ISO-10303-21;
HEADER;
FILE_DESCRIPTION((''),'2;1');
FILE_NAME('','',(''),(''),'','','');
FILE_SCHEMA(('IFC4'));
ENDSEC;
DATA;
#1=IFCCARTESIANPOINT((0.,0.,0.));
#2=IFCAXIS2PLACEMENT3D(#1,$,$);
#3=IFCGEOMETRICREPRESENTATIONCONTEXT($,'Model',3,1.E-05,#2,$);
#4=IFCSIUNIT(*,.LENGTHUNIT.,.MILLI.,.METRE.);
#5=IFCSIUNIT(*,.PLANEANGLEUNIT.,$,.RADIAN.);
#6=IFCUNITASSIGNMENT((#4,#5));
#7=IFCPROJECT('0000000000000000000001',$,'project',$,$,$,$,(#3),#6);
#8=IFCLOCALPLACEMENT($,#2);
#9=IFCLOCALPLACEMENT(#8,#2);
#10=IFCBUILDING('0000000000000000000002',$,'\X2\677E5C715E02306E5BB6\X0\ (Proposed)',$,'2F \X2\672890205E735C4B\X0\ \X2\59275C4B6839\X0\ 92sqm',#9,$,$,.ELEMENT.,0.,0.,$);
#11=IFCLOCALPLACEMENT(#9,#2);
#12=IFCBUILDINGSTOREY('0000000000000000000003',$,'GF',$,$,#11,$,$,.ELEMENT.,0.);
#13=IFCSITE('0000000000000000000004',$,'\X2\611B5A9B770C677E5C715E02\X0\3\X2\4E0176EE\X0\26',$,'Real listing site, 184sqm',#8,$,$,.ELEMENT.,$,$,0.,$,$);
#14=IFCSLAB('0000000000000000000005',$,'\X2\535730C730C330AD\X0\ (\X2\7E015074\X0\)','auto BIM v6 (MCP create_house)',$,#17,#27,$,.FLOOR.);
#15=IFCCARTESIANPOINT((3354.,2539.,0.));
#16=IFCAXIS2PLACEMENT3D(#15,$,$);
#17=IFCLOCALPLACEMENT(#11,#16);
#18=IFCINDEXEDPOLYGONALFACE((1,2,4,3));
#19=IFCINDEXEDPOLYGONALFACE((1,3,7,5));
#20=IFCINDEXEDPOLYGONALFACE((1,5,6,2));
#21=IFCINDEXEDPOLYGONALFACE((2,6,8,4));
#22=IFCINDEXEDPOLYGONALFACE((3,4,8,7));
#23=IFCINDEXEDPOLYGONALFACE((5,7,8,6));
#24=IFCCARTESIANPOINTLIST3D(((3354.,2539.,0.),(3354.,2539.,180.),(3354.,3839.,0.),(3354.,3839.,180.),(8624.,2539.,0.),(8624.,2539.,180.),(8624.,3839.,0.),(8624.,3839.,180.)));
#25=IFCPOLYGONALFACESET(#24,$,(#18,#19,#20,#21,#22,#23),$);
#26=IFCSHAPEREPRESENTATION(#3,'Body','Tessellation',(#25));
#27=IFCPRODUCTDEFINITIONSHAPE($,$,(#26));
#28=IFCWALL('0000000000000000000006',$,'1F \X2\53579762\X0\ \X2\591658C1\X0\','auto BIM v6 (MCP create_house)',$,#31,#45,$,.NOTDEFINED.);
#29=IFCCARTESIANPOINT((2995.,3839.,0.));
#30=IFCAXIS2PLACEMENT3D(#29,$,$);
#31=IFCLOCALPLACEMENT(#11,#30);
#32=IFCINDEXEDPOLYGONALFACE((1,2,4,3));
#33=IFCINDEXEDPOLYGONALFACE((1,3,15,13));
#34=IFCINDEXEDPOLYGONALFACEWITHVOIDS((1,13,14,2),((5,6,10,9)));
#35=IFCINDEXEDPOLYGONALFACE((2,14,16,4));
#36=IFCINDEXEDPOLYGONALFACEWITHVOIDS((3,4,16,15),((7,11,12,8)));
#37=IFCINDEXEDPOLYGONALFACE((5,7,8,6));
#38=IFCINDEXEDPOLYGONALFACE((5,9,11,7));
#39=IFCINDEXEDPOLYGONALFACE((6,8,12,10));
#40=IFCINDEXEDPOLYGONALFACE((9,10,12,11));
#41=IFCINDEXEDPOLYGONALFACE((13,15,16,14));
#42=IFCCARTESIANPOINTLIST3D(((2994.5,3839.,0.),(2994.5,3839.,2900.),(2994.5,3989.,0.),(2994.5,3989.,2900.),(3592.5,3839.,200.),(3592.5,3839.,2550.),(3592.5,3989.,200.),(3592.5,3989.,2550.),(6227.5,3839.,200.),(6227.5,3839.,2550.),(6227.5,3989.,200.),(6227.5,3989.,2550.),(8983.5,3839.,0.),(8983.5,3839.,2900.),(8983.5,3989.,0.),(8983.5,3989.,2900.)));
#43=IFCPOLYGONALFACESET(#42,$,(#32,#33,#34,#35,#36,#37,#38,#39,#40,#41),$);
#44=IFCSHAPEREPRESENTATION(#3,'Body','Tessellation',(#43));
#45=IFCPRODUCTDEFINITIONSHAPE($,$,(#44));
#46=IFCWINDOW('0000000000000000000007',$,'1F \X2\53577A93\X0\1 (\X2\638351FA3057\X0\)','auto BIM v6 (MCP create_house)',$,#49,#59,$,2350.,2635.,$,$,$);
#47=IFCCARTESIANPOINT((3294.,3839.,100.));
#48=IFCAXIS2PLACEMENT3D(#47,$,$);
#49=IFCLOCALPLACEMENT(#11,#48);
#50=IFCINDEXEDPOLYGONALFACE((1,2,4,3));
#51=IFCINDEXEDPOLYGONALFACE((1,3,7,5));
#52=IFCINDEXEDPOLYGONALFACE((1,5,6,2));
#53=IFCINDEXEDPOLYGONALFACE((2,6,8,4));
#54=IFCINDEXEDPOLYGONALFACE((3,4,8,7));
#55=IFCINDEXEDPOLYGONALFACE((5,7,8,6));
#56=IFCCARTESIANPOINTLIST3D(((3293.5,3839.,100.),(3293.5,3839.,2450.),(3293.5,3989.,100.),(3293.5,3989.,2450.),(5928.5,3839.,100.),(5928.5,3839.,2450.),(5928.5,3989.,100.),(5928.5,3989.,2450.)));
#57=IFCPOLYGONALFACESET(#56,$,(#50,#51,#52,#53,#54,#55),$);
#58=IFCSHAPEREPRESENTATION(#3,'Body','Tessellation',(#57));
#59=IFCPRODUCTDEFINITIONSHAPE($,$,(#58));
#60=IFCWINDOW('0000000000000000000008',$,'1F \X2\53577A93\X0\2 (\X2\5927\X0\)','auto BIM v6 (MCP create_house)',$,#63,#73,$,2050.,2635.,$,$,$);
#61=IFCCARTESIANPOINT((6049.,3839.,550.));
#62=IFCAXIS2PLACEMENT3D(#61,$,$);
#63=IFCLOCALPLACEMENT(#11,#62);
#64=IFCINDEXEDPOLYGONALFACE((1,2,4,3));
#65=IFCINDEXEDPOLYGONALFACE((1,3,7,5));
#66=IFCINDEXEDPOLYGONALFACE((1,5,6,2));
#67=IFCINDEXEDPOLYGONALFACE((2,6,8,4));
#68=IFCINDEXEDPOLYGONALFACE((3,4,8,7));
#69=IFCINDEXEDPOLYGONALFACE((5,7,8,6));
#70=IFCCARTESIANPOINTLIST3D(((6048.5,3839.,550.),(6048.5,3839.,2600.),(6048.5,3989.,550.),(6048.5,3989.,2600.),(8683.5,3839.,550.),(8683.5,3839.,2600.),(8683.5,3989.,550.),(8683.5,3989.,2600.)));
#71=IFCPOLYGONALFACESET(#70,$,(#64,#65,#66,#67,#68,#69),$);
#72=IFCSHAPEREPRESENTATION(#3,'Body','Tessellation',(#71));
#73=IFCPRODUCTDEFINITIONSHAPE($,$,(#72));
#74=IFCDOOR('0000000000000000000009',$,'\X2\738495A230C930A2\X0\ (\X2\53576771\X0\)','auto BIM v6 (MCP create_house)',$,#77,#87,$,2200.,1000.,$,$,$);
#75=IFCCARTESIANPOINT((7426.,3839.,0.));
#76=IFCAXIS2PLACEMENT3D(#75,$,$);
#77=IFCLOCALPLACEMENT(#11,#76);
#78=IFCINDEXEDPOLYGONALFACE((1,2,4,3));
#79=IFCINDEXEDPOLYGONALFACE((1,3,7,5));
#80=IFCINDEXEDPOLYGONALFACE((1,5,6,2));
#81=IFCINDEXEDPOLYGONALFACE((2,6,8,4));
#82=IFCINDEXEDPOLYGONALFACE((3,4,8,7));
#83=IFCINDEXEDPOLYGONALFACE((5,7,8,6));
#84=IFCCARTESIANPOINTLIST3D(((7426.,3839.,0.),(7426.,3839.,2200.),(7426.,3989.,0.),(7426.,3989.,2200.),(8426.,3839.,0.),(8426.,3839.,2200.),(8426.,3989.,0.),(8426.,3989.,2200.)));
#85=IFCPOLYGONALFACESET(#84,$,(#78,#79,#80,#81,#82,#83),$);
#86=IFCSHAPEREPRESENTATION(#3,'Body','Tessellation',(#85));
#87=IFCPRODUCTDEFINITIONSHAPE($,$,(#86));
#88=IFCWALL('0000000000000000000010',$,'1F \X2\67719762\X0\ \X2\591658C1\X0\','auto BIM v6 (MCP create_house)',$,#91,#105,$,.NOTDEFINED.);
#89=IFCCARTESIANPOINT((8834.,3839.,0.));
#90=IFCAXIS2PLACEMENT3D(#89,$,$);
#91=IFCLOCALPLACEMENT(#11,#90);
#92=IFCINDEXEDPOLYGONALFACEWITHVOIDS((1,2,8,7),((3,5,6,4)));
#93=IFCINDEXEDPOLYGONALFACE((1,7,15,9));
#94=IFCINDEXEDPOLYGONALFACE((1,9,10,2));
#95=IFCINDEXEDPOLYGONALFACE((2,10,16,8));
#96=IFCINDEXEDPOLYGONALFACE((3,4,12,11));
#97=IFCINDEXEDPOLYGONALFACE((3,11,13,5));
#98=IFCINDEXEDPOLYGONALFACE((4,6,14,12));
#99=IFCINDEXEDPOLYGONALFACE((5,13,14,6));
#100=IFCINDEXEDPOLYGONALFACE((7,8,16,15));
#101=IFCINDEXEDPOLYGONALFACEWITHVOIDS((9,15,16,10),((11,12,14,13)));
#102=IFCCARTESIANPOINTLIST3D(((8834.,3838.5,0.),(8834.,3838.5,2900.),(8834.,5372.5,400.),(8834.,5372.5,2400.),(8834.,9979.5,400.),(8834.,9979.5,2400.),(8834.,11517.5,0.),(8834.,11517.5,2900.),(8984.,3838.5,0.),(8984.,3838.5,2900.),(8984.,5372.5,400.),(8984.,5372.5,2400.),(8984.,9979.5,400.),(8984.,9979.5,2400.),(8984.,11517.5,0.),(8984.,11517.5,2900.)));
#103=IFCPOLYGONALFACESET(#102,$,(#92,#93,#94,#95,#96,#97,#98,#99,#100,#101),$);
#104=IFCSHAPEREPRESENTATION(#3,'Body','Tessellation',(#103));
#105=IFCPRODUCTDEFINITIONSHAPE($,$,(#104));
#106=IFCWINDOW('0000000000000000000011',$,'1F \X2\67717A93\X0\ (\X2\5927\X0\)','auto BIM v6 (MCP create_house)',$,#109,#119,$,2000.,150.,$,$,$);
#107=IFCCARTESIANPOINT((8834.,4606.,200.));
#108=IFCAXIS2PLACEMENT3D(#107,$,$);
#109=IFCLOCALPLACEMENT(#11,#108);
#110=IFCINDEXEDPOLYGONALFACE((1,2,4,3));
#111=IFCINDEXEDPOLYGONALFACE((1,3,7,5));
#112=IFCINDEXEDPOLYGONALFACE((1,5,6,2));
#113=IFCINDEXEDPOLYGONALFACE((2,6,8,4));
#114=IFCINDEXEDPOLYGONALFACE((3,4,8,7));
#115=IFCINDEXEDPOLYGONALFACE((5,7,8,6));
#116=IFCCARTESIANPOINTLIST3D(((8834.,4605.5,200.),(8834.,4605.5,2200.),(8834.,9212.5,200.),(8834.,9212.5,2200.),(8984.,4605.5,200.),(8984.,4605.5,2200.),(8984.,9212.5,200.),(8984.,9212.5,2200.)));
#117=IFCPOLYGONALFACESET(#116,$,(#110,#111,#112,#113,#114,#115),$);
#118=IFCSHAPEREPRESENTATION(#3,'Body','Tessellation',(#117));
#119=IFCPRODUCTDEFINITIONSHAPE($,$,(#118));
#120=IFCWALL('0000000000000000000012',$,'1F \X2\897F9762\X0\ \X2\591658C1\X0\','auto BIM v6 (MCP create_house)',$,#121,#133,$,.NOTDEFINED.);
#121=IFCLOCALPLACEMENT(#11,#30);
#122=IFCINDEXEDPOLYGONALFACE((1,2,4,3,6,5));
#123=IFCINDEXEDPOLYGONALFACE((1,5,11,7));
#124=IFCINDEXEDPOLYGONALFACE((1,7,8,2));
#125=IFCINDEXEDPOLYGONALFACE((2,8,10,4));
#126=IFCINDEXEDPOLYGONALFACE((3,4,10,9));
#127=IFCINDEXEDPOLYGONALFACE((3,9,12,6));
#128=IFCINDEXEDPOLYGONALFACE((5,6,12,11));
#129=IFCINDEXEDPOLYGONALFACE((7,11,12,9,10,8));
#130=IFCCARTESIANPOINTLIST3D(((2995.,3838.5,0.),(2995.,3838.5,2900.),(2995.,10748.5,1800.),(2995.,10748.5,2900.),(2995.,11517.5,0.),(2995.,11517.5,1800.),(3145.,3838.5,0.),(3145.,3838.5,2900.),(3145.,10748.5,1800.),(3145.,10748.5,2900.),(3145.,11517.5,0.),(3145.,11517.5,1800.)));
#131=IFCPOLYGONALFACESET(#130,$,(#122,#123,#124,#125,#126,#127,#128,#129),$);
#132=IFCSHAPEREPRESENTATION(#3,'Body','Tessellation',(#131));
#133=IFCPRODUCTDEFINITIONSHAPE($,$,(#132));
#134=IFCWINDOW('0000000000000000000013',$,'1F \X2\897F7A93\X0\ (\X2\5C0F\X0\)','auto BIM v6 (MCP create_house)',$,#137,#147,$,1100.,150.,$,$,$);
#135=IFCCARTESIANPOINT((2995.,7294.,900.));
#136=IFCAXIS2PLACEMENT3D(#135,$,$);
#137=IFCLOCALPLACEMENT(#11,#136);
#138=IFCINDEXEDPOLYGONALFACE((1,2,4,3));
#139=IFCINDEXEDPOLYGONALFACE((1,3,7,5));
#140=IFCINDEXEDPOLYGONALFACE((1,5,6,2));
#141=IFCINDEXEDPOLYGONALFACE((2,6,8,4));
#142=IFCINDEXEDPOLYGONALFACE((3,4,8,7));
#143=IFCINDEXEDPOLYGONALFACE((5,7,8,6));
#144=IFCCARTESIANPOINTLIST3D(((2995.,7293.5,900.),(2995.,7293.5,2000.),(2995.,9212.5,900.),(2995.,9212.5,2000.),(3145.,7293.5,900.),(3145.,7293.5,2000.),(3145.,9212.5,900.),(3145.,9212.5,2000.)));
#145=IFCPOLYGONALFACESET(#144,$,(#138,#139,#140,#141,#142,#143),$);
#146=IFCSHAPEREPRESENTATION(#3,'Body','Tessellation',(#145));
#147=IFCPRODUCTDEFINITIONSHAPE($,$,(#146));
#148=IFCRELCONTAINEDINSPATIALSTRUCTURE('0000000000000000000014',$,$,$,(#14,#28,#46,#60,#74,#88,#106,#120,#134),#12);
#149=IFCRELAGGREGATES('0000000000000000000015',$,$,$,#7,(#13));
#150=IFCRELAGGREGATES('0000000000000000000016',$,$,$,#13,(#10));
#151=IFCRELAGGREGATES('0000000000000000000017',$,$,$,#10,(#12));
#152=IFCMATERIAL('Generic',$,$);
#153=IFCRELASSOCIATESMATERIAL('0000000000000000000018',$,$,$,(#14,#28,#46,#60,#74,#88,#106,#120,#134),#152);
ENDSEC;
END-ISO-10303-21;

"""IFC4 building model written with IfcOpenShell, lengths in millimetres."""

from ifc_helpers import new_model, si_unit, frame, frame_2d, origin, place, context, project, spatial, rectangle, extrude, material, element, fill, save


model = new_model("IFC4")

# Units and contexts
model_context = context("Model", 3, precision=1e-05, world=origin())
ifc_project = project(units=[si_unit("LENGTHUNIT", "METRE", prefix="MILLI"), si_unit("PLANEANGLEUNIT", "RADIAN")], contexts=[model_context])

# Site, building, storey
site_placement = place(None, origin())
site = spatial("IfcSite", under=ifc_project, at=site_placement, Name="愛媛県松山市3丁目26", ObjectType="Real listing site, 184sqm", CompositionType="ELEMENT", RefElevation=0.0)
building_placement = place(site_placement, origin())
building = spatial("IfcBuilding", under=site, at=building_placement, Name="松山市の家 (Proposed)", ObjectType="2F 木造平屋 大屋根 92sqm", CompositionType="ELEMENT", ElevationOfRefHeight=0.0, ElevationOfTerrain=0.0)
storey_placement = place(building_placement, origin())
storey = spatial("IfcBuildingStorey", under=building, at=storey_placement, Name="GF", CompositionType="ELEMENT", Elevation=0.0)

# Slab
ifc_material = material(Name="Generic")
slab_1_placement = place(storey_placement, frame((3354.0, 2539.0, 0.0)))
element("IfcSlab", 1, at=slab_1_placement, inside=storey, material=ifc_material, Name="南デッキ (縁側)", Description="auto BIM v6 (MCP create_house)", PredefinedType="FLOOR", context=model_context, shape_type="SweptSolid", body=[
    extrude(rectangle(XDim=5270.0, YDim=1300.0, at=frame_2d((2635.0, 650.0))), frame((3354.0, 2539.0, 0.0)), (0.0, 0.0, 1.0), 180.0),
])

# Wall, openings, windows, door
wall_1_placement = place(storey_placement, frame((2995.0, 3839.0, 0.0)))
wall_1 = element("IfcWall", 2, at=wall_1_placement, inside=storey, material=ifc_material, Name="1F 南面 外壁", Description="auto BIM v6 (MCP create_house)", PredefinedType="NOTDEFINED", context=model_context, shape_type="SweptSolid", body=[
    extrude(rectangle(XDim=5989.0, YDim=150.0, at=frame_2d((2994.0, 75.0))), frame((2995.0, 3839.0, 0.0)), (0.0, 0.0, 1.0), 2900.0),
])
opening_1_placement = place(storey_placement, frame((3294.0, 3839.0, 100.0)))
opening_1 = element("IfcOpeningElement", 3, at=opening_1_placement, cuts=wall_1, PredefinedType="NOTDEFINED", context=model_context, shape_type="SweptSolid", body=[
    extrude(rectangle(XDim=2635.0, YDim=150.0, at=frame_2d((1317.0, 75.0))), frame((3294.0, 3839.0, 100.0)), (0.0, 0.0, 1.0), 2350.0),
])
opening_2_placement = place(storey_placement, frame((6049.0, 3839.0, 550.0)))
opening_2 = element("IfcOpeningElement", 4, at=opening_2_placement, cuts=wall_1, PredefinedType="NOTDEFINED", context=model_context, shape_type="SweptSolid", body=[
    extrude(rectangle(XDim=2635.0, YDim=150.0, at=frame_2d((1317.0, 75.0))), frame((6049.0, 3839.0, 550.0)), (0.0, 0.0, 1.0), 2050.0),
])
opening_3_placement = place(storey_placement, frame((7426.0, 3839.0, 0.0)))
opening_3 = element("IfcOpeningElement", 5, at=opening_3_placement, cuts=wall_1, PredefinedType="NOTDEFINED", context=model_context, shape_type="SweptSolid", body=[
    extrude(rectangle(XDim=1000.0, YDim=150.0, at=frame_2d((500.0, 75.0))), frame((7426.0, 3839.0, 0.0)), (0.0, 0.0, 1.0), 2200.0),
])
window_1_placement = place(storey_placement, frame((3294.0, 3839.0, 100.0)))
window_1 = element("IfcWindow", 6, at=window_1_placement, inside=storey, material=ifc_material, Name="1F 南窓1 (掃出し)", Description="auto BIM v6 (MCP create_house)", OverallHeight=2350.0, OverallWidth=2635.0, context=model_context, shape_type="SweptSolid", body=[
    extrude(rectangle(XDim=2635.0, YDim=150.0, at=frame_2d((1317.0, 75.0))), frame((3294.0, 3839.0, 100.0)), (0.0, 0.0, 1.0), 2350.0),
])
fill(opening_1, window_1)
window_2_placement = place(storey_placement, frame((6049.0, 3839.0, 550.0)))
window_2 = element("IfcWindow", 7, at=window_2_placement, inside=storey, material=ifc_material, Name="1F 南窓2 (大)", Description="auto BIM v6 (MCP create_house)", OverallHeight=2050.0, OverallWidth=2635.0, context=model_context, shape_type="SweptSolid", body=[
    extrude(rectangle(XDim=2635.0, YDim=150.0, at=frame_2d((1317.0, 75.0))), frame((6049.0, 3839.0, 550.0)), (0.0, 0.0, 1.0), 2050.0),
])
fill(opening_2, window_2)
door_placement = place(storey_placement, frame((7426.0, 3839.0, 0.0)))
door = element("IfcDoor", 8, at=door_placement, inside=storey, material=ifc_material, Name="玄関ドア (南東)", Description="auto BIM v6 (MCP create_house)", OverallHeight=2200.0, OverallWidth=1000.0, context=model_context, shape_type="SweptSolid", body=[
    extrude(rectangle(XDim=1000.0, YDim=150.0, at=frame_2d((500.0, 75.0))), frame((7426.0, 3839.0, 0.0)), (0.0, 0.0, 1.0), 2200.0),
])
fill(opening_3, door)

# Walls, openings, windows
wall_2_placement = place(storey_placement, frame((8834.0, 3839.0, 0.0)))
wall_2 = element("IfcWall", 9, at=wall_2_placement, inside=storey, material=ifc_material, Name="1F 東面 外壁", Description="auto BIM v6 (MCP create_house)", PredefinedType="NOTDEFINED", context=model_context, shape_type="SweptSolid", body=[
    extrude(rectangle(XDim=150.0, YDim=7679.0, at=frame_2d((75.0, 3839.0))), frame((8834.0, 3839.0, 0.0)), (0.0, 0.0, 1.0), 2900.0),
])
opening_4_placement = place(storey_placement, frame((8834.0, 4606.0, 200.0)))
opening_4 = element("IfcOpeningElement", 10, at=opening_4_placement, cuts=wall_2, PredefinedType="NOTDEFINED", context=model_context, shape_type="SweptSolid", body=[
    extrude(rectangle(XDim=150.0, YDim=4607.0, at=frame_2d((75.0, 2303.0))), frame((8834.0, 4606.0, 200.0)), (0.0, 0.0, 1.0), 2000.0),
])
window_3_placement = place(storey_placement, frame((8834.0, 4606.0, 200.0)))
window_3 = element("IfcWindow", 11, at=window_3_placement, inside=storey, material=ifc_material, Name="1F 東窓 (大)", Description="auto BIM v6 (MCP create_house)", OverallHeight=2000.0, OverallWidth=150.0, context=model_context, shape_type="SweptSolid", body=[
    extrude(rectangle(XDim=150.0, YDim=4607.0, at=frame_2d((75.0, 2303.0))), frame((8834.0, 4606.0, 200.0)), (0.0, 0.0, 1.0), 2000.0),
])
fill(opening_4, window_3)
wall_3_placement = place(storey_placement, frame((2995.0, 3839.0, 0.0)))
wall_3 = element("IfcWall", 12, at=wall_3_placement, inside=storey, material=ifc_material, Name="1F 西面 外壁", Description="auto BIM v6 (MCP create_house)", PredefinedType="NOTDEFINED", context=model_context, shape_type="SweptSolid", body=[
    extrude(rectangle(XDim=150.0, YDim=7679.0, at=frame_2d((75.0, 3839.0))), frame((2995.0, 3839.0, 0.0)), (0.0, 0.0, 1.0), 2900.0),
])
opening_5_placement = place(storey_placement, frame((2995.0, 7294.0, 900.0)))
opening_5 = element("IfcOpeningElement", 13, at=opening_5_placement, cuts=wall_3, PredefinedType="NOTDEFINED", context=model_context, shape_type="SweptSolid", body=[
    extrude(rectangle(XDim=150.0, YDim=1919.0, at=frame_2d((75.0, 959.0))), frame((2995.0, 7294.0, 900.0)), (0.0, 0.0, 1.0), 1100.0),
])
window_4_placement = place(storey_placement, frame((2995.0, 7294.0, 900.0)))
window_4 = element("IfcWindow", 14, at=window_4_placement, inside=storey, material=ifc_material, Name="1F 西窓 (小)", Description="auto BIM v6 (MCP create_house)", OverallHeight=1100.0, OverallWidth=150.0, context=model_context, shape_type="SweptSolid", body=[
    extrude(rectangle(XDim=150.0, YDim=1919.0, at=frame_2d((75.0, 959.0))), frame((2995.0, 7294.0, 900.0)), (0.0, 0.0, 1.0), 1100.0),
])
fill(opening_5, window_4)

save(model, "model.ifc")
